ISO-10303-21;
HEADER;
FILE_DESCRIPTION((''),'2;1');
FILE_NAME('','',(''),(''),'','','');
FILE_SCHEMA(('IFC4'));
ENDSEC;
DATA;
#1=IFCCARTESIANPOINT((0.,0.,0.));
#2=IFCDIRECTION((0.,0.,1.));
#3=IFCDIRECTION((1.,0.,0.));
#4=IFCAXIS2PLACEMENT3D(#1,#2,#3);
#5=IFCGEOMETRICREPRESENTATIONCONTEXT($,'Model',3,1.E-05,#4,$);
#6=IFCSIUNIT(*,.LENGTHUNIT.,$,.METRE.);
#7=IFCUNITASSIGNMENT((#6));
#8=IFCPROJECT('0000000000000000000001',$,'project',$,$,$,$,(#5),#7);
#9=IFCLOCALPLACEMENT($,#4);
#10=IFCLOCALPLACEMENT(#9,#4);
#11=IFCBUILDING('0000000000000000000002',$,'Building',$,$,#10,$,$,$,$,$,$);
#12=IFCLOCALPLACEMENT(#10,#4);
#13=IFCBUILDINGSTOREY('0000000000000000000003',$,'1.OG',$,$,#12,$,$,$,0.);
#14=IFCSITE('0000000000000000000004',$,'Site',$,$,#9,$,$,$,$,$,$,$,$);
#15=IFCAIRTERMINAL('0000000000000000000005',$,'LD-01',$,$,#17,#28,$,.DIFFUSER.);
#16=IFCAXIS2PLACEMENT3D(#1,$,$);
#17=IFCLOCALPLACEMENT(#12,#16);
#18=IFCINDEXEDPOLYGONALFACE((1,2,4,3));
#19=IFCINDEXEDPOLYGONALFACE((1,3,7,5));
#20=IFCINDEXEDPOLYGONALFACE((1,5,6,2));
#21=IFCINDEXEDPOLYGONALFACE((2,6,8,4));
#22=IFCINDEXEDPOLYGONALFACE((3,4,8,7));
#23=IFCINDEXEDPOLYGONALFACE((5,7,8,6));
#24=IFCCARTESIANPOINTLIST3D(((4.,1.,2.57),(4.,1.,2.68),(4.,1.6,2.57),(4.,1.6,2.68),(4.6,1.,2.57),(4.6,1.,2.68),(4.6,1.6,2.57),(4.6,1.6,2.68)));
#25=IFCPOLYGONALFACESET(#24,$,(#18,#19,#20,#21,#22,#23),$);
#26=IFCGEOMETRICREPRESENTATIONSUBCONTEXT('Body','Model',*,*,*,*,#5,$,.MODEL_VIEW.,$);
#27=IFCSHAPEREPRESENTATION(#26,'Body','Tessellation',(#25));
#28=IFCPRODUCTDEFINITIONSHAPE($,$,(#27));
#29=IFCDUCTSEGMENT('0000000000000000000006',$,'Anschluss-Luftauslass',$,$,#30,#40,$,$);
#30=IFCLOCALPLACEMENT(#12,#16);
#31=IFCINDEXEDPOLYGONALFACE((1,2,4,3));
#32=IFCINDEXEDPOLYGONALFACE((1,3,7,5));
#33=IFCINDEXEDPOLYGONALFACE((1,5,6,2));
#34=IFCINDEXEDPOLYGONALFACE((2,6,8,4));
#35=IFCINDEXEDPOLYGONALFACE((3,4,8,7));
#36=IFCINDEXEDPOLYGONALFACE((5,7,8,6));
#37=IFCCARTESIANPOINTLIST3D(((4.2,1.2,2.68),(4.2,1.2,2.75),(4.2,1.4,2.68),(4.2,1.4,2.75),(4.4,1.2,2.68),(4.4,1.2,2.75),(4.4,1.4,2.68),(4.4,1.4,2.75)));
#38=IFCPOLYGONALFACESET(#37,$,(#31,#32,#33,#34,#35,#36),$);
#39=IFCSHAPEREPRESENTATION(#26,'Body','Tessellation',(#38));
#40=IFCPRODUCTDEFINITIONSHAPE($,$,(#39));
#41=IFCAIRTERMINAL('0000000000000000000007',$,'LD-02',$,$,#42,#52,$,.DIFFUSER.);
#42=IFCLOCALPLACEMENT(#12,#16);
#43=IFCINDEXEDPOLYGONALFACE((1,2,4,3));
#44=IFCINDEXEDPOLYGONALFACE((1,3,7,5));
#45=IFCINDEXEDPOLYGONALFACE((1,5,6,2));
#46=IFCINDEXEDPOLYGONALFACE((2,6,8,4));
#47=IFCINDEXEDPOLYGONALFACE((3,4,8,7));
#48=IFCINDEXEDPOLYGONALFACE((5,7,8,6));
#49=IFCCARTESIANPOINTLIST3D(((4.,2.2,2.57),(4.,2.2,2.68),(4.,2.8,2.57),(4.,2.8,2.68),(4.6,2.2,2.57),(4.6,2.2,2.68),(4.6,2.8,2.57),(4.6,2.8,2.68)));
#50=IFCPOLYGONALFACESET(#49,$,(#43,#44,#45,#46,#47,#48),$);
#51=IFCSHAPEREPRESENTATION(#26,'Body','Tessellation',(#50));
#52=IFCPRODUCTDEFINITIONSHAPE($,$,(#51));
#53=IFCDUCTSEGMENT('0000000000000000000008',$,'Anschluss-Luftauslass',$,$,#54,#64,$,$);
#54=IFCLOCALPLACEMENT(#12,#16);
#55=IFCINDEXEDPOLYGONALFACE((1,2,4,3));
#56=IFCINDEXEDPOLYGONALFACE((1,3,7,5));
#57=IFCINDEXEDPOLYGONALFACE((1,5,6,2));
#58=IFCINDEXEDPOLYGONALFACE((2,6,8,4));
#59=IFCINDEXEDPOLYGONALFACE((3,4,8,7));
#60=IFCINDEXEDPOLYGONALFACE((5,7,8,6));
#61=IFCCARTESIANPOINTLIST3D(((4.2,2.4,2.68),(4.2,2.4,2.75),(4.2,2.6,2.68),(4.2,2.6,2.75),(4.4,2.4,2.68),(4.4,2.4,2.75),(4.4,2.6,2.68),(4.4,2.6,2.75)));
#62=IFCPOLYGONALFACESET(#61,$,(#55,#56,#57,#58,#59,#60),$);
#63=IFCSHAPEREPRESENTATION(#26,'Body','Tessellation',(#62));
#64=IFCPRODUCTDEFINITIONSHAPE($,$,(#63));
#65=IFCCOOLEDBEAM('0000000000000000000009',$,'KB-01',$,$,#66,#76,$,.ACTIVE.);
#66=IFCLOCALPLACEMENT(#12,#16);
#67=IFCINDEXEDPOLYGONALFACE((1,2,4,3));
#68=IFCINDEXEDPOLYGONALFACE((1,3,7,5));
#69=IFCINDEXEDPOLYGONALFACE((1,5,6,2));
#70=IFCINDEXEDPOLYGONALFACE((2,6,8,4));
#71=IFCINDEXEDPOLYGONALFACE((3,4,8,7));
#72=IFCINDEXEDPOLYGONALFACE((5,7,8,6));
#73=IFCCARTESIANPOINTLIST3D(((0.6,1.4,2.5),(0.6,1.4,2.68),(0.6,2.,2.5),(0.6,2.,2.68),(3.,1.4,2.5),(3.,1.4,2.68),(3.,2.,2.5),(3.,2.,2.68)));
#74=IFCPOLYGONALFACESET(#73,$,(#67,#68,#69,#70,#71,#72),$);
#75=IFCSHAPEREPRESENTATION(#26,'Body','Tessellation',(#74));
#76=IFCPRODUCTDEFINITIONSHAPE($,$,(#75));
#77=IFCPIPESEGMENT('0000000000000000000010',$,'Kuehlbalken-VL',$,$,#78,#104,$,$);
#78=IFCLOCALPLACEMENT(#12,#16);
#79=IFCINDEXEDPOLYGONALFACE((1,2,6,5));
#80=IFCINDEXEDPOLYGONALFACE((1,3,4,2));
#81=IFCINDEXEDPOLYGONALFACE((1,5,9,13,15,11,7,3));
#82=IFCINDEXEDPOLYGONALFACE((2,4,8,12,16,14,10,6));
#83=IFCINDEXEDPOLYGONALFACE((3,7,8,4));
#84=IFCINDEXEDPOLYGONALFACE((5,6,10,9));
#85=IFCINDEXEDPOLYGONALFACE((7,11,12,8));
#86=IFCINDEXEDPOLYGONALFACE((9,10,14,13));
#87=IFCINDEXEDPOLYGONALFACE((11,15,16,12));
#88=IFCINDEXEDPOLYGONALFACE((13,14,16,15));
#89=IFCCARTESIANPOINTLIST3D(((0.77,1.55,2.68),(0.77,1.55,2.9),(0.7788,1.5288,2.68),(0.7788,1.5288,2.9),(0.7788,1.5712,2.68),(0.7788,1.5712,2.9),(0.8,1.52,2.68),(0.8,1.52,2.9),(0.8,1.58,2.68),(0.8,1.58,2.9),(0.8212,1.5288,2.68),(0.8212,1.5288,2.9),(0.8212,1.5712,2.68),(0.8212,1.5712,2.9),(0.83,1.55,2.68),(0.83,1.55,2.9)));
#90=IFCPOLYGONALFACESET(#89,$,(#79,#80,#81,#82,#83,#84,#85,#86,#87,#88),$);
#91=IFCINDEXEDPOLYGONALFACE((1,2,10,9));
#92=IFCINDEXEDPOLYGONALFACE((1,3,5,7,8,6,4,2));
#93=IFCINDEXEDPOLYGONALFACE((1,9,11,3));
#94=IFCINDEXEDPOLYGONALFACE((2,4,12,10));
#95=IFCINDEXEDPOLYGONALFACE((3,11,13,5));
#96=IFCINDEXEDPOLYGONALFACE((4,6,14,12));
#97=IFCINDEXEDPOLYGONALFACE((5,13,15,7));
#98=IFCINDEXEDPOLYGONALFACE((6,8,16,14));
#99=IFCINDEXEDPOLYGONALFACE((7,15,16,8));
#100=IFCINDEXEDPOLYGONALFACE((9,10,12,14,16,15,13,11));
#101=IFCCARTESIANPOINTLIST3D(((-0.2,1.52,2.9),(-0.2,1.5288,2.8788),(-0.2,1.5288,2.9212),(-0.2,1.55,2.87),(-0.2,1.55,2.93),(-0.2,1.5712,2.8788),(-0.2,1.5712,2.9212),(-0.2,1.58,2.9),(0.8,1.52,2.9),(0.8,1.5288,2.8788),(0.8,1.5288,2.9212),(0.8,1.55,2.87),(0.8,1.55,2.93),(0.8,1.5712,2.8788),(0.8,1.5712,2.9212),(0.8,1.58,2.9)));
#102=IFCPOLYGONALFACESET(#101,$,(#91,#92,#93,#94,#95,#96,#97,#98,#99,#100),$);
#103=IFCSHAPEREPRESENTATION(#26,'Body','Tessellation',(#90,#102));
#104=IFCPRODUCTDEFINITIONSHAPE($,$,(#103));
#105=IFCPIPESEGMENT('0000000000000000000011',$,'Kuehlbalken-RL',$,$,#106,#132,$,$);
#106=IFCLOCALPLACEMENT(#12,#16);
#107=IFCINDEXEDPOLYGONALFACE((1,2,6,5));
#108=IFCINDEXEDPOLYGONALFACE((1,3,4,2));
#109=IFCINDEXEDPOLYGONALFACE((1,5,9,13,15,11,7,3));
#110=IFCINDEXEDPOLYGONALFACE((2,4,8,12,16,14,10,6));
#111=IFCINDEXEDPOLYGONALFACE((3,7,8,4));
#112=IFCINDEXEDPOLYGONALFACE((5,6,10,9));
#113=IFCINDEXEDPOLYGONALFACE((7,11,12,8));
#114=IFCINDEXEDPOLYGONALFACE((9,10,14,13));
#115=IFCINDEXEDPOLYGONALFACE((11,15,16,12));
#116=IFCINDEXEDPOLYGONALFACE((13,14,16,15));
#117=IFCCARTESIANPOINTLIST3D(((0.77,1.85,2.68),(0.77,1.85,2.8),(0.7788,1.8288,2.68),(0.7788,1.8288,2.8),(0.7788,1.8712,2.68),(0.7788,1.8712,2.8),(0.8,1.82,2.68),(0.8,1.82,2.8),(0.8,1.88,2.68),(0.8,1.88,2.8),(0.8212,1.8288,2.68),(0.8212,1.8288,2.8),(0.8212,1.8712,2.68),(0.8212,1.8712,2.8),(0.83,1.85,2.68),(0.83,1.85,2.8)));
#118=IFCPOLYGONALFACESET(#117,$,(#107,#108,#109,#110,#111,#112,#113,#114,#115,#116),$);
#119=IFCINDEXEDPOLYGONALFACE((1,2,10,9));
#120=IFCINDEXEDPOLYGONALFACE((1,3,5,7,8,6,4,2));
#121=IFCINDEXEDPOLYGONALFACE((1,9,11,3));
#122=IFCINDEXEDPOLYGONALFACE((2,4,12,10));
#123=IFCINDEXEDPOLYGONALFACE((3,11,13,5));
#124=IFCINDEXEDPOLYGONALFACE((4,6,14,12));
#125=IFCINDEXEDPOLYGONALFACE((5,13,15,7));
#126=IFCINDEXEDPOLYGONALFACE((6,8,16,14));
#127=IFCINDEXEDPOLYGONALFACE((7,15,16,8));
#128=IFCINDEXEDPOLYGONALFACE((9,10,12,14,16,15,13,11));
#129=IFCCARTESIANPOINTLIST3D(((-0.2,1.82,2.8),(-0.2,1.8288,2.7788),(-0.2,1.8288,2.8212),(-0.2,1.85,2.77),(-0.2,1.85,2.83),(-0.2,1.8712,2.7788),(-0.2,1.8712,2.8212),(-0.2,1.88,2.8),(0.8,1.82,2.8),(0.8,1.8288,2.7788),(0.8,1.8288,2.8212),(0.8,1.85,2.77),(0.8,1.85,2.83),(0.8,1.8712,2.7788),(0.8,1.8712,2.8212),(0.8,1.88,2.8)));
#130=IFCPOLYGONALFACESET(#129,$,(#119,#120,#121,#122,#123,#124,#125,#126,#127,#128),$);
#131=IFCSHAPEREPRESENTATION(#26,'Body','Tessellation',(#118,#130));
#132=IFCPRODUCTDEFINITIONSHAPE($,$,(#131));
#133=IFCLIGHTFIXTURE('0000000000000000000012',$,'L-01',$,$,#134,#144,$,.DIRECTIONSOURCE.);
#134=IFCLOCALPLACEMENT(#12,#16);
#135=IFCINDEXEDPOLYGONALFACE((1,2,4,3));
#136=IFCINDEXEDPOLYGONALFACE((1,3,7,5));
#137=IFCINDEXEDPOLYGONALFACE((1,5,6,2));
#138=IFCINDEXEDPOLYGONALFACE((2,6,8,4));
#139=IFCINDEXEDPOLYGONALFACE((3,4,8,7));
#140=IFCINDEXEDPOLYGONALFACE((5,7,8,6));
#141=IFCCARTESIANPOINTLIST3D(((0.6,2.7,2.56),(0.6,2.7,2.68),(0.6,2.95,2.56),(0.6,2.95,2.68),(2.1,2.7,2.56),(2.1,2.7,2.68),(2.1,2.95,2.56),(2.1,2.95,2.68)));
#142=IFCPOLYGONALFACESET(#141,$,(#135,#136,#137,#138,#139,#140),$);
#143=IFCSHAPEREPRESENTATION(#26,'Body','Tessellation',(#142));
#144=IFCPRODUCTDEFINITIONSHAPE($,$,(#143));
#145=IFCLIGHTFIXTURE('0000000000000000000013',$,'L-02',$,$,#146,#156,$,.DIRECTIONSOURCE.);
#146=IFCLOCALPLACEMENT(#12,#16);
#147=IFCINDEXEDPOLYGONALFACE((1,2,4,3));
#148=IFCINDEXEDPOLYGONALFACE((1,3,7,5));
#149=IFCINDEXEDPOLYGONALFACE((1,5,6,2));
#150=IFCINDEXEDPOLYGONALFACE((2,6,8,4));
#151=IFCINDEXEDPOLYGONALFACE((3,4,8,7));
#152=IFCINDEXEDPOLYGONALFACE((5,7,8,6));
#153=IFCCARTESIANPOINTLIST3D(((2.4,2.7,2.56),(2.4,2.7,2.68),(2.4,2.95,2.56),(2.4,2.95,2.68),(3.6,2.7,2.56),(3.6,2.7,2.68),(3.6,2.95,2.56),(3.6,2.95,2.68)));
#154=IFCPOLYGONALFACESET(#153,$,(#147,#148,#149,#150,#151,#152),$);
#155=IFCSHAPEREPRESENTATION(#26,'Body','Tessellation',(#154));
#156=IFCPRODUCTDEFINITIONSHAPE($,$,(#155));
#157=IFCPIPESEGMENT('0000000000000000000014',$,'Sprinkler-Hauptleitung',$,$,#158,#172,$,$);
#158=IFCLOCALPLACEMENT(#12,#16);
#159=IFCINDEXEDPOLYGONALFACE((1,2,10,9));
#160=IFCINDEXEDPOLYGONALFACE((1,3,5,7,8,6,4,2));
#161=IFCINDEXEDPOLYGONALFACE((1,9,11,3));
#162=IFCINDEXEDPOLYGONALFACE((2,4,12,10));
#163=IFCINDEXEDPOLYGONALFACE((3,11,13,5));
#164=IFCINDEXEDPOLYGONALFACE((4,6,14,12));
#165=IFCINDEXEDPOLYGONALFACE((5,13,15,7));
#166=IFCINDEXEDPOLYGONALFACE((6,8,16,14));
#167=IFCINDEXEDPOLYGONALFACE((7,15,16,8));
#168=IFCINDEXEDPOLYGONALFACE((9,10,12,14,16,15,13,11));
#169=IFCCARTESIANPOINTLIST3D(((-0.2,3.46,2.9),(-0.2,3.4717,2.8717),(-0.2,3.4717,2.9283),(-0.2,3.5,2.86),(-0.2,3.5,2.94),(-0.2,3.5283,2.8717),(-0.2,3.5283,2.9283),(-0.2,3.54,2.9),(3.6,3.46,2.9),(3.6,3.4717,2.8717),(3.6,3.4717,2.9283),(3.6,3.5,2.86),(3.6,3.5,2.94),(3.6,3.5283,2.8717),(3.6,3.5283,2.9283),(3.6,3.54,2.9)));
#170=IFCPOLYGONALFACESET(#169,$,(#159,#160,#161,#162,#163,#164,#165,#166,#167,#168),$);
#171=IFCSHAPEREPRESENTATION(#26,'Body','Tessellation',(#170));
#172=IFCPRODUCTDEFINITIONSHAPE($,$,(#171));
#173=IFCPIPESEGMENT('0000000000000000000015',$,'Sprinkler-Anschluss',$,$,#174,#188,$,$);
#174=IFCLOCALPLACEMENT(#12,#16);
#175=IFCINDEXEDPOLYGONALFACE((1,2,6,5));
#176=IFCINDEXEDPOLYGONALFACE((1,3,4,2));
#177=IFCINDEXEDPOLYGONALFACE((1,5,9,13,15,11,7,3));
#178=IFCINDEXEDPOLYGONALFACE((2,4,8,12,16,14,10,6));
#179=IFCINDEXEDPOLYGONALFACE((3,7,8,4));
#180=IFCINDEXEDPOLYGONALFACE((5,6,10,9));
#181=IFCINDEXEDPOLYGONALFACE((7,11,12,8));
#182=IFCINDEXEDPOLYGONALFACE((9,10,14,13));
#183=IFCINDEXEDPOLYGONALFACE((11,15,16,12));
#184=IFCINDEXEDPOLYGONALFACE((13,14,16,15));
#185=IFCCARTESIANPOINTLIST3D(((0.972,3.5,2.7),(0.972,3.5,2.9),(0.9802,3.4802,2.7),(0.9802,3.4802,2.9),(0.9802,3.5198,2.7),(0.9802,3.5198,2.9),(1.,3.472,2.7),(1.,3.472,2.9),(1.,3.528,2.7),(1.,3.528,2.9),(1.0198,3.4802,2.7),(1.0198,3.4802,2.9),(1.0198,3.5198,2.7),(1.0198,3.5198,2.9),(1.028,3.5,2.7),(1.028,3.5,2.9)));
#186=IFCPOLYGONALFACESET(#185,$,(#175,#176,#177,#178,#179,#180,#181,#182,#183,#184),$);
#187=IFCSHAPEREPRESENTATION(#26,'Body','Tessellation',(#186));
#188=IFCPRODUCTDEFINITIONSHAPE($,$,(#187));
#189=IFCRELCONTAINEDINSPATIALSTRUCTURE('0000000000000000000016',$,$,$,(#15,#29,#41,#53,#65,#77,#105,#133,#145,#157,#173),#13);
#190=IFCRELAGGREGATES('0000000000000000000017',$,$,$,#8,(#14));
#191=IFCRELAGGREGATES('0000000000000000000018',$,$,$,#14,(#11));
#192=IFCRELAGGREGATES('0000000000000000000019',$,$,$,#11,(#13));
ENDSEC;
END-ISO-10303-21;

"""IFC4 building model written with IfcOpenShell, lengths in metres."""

from ifc_helpers import new_model, si_unit, frame, origin_with_axes, place, context, subcontext, project, spatial, polyline, outline, extrude, element, save


model = new_model("IFC4")

# Units and contexts
model_context = context("Model", 3, precision=1e-05, world=origin_with_axes())
body_context = subcontext(model_context, "Body", "Model", "MODEL_VIEW")
ifc_project = project(units=[si_unit("LENGTHUNIT", "METRE")], contexts=[model_context])

# Site, building, storey
site_placement = place(None, origin_with_axes())
site = spatial("IfcSite", under=ifc_project, at=site_placement, Name="Site")
building_placement = place(site_placement, origin_with_axes())
building = spatial("IfcBuilding", under=site, at=building_placement, Name="Building")
storey_placement = place(building_placement, origin_with_axes())
storey = spatial("IfcBuildingStorey", under=building, at=storey_placement, Name="1.OG", Elevation=0.0)

# Air terminal
air_terminal_1_placement = place(storey_placement, origin_with_axes())
element("IfcAirTerminal", 1, at=air_terminal_1_placement, inside=storey, Name="LD-01", PredefinedType="DIFFUSER", context=body_context, shape_type="SweptSolid", body=[
    extrude(outline(polyline([(4.0, 1.0, 0.0), (4.6, 1.0, 0.0), (4.6, 1.6, 0.0), (4.0, 1.6, 0.0), (4.0, 1.0, 0.0)])), frame((0.0, 0.0, 2.57), z_axis=(0.0, 0.0, 1.0), x_axis=(1.0, 0.0, 0.0)), (0.0, 0.0, 1.0), 0.11),
])

# Duct segment
duct_segment_1_placement = place(storey_placement, origin_with_axes())
element("IfcDuctSegment", 2, at=duct_segment_1_placement, inside=storey, Name="Anschluss-Luftauslass", context=body_context, shape_type="SweptSolid", body=[
    extrude(outline(polyline([(-0.1, -0.1, 0.0), (0.1, -0.1, 0.0), (0.1, 0.1, 0.0), (-0.1, 0.1, 0.0), (-0.1, -0.1, 0.0)])), frame((4.3, 1.3, 2.68), z_axis=(0.0, 0.0, 1.0), x_axis=(1.0, 0.0, 0.0)), (0.0, 0.0, 1.0), 0.07),
])

# Air terminal
air_terminal_2_placement = place(storey_placement, origin_with_axes())
element("IfcAirTerminal", 3, at=air_terminal_2_placement, inside=storey, Name="LD-02", PredefinedType="DIFFUSER", context=body_context, shape_type="SweptSolid", body=[
    extrude(outline(polyline([(4.0, 2.2, 0.0), (4.6, 2.2, 0.0), (4.6, 2.8, 0.0), (4.0, 2.8, 0.0), (4.0, 2.2, 0.0)])), frame((0.0, 0.0, 2.57), z_axis=(0.0, 0.0, 1.0), x_axis=(1.0, 0.0, 0.0)), (0.0, 0.0, 1.0), 0.11),
])

# Duct segment
duct_segment_2_placement = place(storey_placement, origin_with_axes())
element("IfcDuctSegment", 4, at=duct_segment_2_placement, inside=storey, Name="Anschluss-Luftauslass", context=body_context, shape_type="SweptSolid", body=[
    extrude(outline(polyline([(-0.1, -0.1, 0.0), (0.1, -0.1, 0.0), (0.1, 0.1, 0.0), (-0.1, 0.1, 0.0), (-0.1, -0.1, 0.0)])), frame((4.3, 2.5, 2.68), z_axis=(0.0, 0.0, 1.0), x_axis=(1.0, 0.0, 0.0)), (0.0, 0.0, 1.0), 0.07),
])

# Cooled beam
cooled_beam_placement = place(storey_placement, origin_with_axes())
element("IfcCooledBeam", 5, at=cooled_beam_placement, inside=storey, Name="KB-01", PredefinedType="ACTIVE", context=body_context, shape_type="SweptSolid", body=[
    extrude(outline(polyline([(0.6, 1.4, 0.0), (3.0, 1.4, 0.0), (3.0, 2.0, 0.0), (0.6, 2.0, 0.0), (0.6, 1.4, 0.0)])), frame((0.0, 0.0, 2.5), z_axis=(0.0, 0.0, 1.0), x_axis=(1.0, 0.0, 0.0)), (0.0, 0.0, 1.0), 0.18),
])

# Pipe segments
pipe_segment_1_placement = place(storey_placement, origin_with_axes())
element("IfcPipeSegment", 6, at=pipe_segment_1_placement, inside=storey, Name="Kuehlbalken-VL", context=body_context, shape_type="SweptSolid", body=[
    extrude(outline(polyline([(0.03, 0.0, 0.0), (0.0212, 0.0212, 0.0), (0.0, 0.03, 0.0), (-0.0212, 0.0212, 0.0), (-0.03, 0.0, 0.0), (-0.0212, -0.0212, 0.0), (0.0, -0.03, 0.0), (0.0212, -0.0212, 0.0), (0.03, 0.0, 0.0)])), frame((0.8, 1.55, 2.68), z_axis=(0.0, 0.0, 1.0), x_axis=(1.0, 0.0, 0.0)), (0.0, 0.0, 1.0), 0.22),
    extrude(outline(polyline([(0.03, 0.0, 0.0), (0.0212, 0.0212, 0.0), (0.0, 0.03, 0.0), (-0.0212, 0.0212, 0.0), (-0.03, 0.0, 0.0), (-0.0212, -0.0212, 0.0), (0.0, -0.03, 0.0), (0.0212, -0.0212, 0.0), (0.03, 0.0, 0.0)])), frame((0.8, 1.55, 2.9), z_axis=(-1.0, 0.0, 0.0), x_axis=(0.0, -1.0, 0.0)), (0.0, 0.0, 1.0), 1.0),
])
pipe_segment_2_placement = place(storey_placement, origin_with_axes())
element("IfcPipeSegment", 7, at=pipe_segment_2_placement, inside=storey, Name="Kuehlbalken-RL", context=body_context, shape_type="SweptSolid", body=[
    extrude(outline(polyline([(0.03, 0.0, 0.0), (0.0212, 0.0212, 0.0), (0.0, 0.03, 0.0), (-0.0212, 0.0212, 0.0), (-0.03, 0.0, 0.0), (-0.0212, -0.0212, 0.0), (0.0, -0.03, 0.0), (0.0212, -0.0212, 0.0), (0.03, 0.0, 0.0)])), frame((0.8, 1.85, 2.68), z_axis=(0.0, 0.0, 1.0), x_axis=(1.0, 0.0, 0.0)), (0.0, 0.0, 1.0), 0.12),
    extrude(outline(polyline([(0.03, 0.0, 0.0), (0.0212, 0.0212, 0.0), (0.0, 0.03, 0.0), (-0.0212, 0.0212, 0.0), (-0.03, 0.0, 0.0), (-0.0212, -0.0212, 0.0), (0.0, -0.03, 0.0), (0.0212, -0.0212, 0.0), (0.03, 0.0, 0.0)])), frame((0.8, 1.85, 2.8), z_axis=(-1.0, 0.0, 0.0), x_axis=(0.0, -1.0, 0.0)), (0.0, 0.0, 1.0), 1.0),
])

# Light fixtures
light_fixture_1_placement = place(storey_placement, origin_with_axes())
element("IfcLightFixture", 8, at=light_fixture_1_placement, inside=storey, Name="L-01", PredefinedType="DIRECTIONSOURCE", context=body_context, shape_type="SweptSolid", body=[
    extrude(outline(polyline([(0.6, 2.7, 0.0), (2.1, 2.7, 0.0), (2.1, 2.95, 0.0), (0.6, 2.95, 0.0), (0.6, 2.7, 0.0)])), frame((0.0, 0.0, 2.56), z_axis=(0.0, 0.0, 1.0), x_axis=(1.0, 0.0, 0.0)), (0.0, 0.0, 1.0), 0.12),
])
light_fixture_2_placement = place(storey_placement, origin_with_axes())
element("IfcLightFixture", 9, at=light_fixture_2_placement, inside=storey, Name="L-02", PredefinedType="DIRECTIONSOURCE", context=body_context, shape_type="SweptSolid", body=[
    extrude(outline(polyline([(2.4, 2.7, 0.0), (3.6, 2.7, 0.0), (3.6, 2.95, 0.0), (2.4, 2.95, 0.0), (2.4, 2.7, 0.0)])), frame((0.0, 0.0, 2.56), z_axis=(0.0, 0.0, 1.0), x_axis=(1.0, 0.0, 0.0)), (0.0, 0.0, 1.0), 0.12),
])

# Pipe segments
pipe_segment_3_placement = place(storey_placement, origin_with_axes())
element("IfcPipeSegment", 10, at=pipe_segment_3_placement, inside=storey, Name="Sprinkler-Hauptleitung", context=body_context, shape_type="SweptSolid", body=[
    extrude(outline(polyline([(0.04, 0.0, 0.0), (0.0283, 0.0283, 0.0), (0.0, 0.04, 0.0), (-0.0283, 0.0283, 0.0), (-0.04, 0.0, 0.0), (-0.0283, -0.0283, 0.0), (0.0, -0.04, 0.0), (0.0283, -0.0283, 0.0), (0.04, 0.0, 0.0)])), frame((-0.2, 3.5, 2.9), z_axis=(1.0, 0.0, 0.0), x_axis=(0.0, 1.0, 0.0)), (0.0, 0.0, 1.0), 3.8),
])
pipe_segment_4_placement = place(storey_placement, origin_with_axes())
element("IfcPipeSegment", 11, at=pipe_segment_4_placement, inside=storey, Name="Sprinkler-Anschluss", context=body_context, shape_type="SweptSolid", body=[
    extrude(outline(polyline([(0.028, 0.0, 0.0), (0.0198, 0.0198, 0.0), (0.0, 0.028, 0.0), (-0.0198, 0.0198, 0.0), (-0.028, 0.0, 0.0), (-0.0198, -0.0198, 0.0), (0.0, -0.028, 0.0), (0.0198, -0.0198, 0.0), (0.028, 0.0, 0.0)])), frame((1.0, 3.5, 2.7), z_axis=(0.0, 0.0, 1.0), x_axis=(1.0, 0.0, 0.0)), (0.0, 0.0, 1.0), 0.2),
])

save(model, "model.ifc")
